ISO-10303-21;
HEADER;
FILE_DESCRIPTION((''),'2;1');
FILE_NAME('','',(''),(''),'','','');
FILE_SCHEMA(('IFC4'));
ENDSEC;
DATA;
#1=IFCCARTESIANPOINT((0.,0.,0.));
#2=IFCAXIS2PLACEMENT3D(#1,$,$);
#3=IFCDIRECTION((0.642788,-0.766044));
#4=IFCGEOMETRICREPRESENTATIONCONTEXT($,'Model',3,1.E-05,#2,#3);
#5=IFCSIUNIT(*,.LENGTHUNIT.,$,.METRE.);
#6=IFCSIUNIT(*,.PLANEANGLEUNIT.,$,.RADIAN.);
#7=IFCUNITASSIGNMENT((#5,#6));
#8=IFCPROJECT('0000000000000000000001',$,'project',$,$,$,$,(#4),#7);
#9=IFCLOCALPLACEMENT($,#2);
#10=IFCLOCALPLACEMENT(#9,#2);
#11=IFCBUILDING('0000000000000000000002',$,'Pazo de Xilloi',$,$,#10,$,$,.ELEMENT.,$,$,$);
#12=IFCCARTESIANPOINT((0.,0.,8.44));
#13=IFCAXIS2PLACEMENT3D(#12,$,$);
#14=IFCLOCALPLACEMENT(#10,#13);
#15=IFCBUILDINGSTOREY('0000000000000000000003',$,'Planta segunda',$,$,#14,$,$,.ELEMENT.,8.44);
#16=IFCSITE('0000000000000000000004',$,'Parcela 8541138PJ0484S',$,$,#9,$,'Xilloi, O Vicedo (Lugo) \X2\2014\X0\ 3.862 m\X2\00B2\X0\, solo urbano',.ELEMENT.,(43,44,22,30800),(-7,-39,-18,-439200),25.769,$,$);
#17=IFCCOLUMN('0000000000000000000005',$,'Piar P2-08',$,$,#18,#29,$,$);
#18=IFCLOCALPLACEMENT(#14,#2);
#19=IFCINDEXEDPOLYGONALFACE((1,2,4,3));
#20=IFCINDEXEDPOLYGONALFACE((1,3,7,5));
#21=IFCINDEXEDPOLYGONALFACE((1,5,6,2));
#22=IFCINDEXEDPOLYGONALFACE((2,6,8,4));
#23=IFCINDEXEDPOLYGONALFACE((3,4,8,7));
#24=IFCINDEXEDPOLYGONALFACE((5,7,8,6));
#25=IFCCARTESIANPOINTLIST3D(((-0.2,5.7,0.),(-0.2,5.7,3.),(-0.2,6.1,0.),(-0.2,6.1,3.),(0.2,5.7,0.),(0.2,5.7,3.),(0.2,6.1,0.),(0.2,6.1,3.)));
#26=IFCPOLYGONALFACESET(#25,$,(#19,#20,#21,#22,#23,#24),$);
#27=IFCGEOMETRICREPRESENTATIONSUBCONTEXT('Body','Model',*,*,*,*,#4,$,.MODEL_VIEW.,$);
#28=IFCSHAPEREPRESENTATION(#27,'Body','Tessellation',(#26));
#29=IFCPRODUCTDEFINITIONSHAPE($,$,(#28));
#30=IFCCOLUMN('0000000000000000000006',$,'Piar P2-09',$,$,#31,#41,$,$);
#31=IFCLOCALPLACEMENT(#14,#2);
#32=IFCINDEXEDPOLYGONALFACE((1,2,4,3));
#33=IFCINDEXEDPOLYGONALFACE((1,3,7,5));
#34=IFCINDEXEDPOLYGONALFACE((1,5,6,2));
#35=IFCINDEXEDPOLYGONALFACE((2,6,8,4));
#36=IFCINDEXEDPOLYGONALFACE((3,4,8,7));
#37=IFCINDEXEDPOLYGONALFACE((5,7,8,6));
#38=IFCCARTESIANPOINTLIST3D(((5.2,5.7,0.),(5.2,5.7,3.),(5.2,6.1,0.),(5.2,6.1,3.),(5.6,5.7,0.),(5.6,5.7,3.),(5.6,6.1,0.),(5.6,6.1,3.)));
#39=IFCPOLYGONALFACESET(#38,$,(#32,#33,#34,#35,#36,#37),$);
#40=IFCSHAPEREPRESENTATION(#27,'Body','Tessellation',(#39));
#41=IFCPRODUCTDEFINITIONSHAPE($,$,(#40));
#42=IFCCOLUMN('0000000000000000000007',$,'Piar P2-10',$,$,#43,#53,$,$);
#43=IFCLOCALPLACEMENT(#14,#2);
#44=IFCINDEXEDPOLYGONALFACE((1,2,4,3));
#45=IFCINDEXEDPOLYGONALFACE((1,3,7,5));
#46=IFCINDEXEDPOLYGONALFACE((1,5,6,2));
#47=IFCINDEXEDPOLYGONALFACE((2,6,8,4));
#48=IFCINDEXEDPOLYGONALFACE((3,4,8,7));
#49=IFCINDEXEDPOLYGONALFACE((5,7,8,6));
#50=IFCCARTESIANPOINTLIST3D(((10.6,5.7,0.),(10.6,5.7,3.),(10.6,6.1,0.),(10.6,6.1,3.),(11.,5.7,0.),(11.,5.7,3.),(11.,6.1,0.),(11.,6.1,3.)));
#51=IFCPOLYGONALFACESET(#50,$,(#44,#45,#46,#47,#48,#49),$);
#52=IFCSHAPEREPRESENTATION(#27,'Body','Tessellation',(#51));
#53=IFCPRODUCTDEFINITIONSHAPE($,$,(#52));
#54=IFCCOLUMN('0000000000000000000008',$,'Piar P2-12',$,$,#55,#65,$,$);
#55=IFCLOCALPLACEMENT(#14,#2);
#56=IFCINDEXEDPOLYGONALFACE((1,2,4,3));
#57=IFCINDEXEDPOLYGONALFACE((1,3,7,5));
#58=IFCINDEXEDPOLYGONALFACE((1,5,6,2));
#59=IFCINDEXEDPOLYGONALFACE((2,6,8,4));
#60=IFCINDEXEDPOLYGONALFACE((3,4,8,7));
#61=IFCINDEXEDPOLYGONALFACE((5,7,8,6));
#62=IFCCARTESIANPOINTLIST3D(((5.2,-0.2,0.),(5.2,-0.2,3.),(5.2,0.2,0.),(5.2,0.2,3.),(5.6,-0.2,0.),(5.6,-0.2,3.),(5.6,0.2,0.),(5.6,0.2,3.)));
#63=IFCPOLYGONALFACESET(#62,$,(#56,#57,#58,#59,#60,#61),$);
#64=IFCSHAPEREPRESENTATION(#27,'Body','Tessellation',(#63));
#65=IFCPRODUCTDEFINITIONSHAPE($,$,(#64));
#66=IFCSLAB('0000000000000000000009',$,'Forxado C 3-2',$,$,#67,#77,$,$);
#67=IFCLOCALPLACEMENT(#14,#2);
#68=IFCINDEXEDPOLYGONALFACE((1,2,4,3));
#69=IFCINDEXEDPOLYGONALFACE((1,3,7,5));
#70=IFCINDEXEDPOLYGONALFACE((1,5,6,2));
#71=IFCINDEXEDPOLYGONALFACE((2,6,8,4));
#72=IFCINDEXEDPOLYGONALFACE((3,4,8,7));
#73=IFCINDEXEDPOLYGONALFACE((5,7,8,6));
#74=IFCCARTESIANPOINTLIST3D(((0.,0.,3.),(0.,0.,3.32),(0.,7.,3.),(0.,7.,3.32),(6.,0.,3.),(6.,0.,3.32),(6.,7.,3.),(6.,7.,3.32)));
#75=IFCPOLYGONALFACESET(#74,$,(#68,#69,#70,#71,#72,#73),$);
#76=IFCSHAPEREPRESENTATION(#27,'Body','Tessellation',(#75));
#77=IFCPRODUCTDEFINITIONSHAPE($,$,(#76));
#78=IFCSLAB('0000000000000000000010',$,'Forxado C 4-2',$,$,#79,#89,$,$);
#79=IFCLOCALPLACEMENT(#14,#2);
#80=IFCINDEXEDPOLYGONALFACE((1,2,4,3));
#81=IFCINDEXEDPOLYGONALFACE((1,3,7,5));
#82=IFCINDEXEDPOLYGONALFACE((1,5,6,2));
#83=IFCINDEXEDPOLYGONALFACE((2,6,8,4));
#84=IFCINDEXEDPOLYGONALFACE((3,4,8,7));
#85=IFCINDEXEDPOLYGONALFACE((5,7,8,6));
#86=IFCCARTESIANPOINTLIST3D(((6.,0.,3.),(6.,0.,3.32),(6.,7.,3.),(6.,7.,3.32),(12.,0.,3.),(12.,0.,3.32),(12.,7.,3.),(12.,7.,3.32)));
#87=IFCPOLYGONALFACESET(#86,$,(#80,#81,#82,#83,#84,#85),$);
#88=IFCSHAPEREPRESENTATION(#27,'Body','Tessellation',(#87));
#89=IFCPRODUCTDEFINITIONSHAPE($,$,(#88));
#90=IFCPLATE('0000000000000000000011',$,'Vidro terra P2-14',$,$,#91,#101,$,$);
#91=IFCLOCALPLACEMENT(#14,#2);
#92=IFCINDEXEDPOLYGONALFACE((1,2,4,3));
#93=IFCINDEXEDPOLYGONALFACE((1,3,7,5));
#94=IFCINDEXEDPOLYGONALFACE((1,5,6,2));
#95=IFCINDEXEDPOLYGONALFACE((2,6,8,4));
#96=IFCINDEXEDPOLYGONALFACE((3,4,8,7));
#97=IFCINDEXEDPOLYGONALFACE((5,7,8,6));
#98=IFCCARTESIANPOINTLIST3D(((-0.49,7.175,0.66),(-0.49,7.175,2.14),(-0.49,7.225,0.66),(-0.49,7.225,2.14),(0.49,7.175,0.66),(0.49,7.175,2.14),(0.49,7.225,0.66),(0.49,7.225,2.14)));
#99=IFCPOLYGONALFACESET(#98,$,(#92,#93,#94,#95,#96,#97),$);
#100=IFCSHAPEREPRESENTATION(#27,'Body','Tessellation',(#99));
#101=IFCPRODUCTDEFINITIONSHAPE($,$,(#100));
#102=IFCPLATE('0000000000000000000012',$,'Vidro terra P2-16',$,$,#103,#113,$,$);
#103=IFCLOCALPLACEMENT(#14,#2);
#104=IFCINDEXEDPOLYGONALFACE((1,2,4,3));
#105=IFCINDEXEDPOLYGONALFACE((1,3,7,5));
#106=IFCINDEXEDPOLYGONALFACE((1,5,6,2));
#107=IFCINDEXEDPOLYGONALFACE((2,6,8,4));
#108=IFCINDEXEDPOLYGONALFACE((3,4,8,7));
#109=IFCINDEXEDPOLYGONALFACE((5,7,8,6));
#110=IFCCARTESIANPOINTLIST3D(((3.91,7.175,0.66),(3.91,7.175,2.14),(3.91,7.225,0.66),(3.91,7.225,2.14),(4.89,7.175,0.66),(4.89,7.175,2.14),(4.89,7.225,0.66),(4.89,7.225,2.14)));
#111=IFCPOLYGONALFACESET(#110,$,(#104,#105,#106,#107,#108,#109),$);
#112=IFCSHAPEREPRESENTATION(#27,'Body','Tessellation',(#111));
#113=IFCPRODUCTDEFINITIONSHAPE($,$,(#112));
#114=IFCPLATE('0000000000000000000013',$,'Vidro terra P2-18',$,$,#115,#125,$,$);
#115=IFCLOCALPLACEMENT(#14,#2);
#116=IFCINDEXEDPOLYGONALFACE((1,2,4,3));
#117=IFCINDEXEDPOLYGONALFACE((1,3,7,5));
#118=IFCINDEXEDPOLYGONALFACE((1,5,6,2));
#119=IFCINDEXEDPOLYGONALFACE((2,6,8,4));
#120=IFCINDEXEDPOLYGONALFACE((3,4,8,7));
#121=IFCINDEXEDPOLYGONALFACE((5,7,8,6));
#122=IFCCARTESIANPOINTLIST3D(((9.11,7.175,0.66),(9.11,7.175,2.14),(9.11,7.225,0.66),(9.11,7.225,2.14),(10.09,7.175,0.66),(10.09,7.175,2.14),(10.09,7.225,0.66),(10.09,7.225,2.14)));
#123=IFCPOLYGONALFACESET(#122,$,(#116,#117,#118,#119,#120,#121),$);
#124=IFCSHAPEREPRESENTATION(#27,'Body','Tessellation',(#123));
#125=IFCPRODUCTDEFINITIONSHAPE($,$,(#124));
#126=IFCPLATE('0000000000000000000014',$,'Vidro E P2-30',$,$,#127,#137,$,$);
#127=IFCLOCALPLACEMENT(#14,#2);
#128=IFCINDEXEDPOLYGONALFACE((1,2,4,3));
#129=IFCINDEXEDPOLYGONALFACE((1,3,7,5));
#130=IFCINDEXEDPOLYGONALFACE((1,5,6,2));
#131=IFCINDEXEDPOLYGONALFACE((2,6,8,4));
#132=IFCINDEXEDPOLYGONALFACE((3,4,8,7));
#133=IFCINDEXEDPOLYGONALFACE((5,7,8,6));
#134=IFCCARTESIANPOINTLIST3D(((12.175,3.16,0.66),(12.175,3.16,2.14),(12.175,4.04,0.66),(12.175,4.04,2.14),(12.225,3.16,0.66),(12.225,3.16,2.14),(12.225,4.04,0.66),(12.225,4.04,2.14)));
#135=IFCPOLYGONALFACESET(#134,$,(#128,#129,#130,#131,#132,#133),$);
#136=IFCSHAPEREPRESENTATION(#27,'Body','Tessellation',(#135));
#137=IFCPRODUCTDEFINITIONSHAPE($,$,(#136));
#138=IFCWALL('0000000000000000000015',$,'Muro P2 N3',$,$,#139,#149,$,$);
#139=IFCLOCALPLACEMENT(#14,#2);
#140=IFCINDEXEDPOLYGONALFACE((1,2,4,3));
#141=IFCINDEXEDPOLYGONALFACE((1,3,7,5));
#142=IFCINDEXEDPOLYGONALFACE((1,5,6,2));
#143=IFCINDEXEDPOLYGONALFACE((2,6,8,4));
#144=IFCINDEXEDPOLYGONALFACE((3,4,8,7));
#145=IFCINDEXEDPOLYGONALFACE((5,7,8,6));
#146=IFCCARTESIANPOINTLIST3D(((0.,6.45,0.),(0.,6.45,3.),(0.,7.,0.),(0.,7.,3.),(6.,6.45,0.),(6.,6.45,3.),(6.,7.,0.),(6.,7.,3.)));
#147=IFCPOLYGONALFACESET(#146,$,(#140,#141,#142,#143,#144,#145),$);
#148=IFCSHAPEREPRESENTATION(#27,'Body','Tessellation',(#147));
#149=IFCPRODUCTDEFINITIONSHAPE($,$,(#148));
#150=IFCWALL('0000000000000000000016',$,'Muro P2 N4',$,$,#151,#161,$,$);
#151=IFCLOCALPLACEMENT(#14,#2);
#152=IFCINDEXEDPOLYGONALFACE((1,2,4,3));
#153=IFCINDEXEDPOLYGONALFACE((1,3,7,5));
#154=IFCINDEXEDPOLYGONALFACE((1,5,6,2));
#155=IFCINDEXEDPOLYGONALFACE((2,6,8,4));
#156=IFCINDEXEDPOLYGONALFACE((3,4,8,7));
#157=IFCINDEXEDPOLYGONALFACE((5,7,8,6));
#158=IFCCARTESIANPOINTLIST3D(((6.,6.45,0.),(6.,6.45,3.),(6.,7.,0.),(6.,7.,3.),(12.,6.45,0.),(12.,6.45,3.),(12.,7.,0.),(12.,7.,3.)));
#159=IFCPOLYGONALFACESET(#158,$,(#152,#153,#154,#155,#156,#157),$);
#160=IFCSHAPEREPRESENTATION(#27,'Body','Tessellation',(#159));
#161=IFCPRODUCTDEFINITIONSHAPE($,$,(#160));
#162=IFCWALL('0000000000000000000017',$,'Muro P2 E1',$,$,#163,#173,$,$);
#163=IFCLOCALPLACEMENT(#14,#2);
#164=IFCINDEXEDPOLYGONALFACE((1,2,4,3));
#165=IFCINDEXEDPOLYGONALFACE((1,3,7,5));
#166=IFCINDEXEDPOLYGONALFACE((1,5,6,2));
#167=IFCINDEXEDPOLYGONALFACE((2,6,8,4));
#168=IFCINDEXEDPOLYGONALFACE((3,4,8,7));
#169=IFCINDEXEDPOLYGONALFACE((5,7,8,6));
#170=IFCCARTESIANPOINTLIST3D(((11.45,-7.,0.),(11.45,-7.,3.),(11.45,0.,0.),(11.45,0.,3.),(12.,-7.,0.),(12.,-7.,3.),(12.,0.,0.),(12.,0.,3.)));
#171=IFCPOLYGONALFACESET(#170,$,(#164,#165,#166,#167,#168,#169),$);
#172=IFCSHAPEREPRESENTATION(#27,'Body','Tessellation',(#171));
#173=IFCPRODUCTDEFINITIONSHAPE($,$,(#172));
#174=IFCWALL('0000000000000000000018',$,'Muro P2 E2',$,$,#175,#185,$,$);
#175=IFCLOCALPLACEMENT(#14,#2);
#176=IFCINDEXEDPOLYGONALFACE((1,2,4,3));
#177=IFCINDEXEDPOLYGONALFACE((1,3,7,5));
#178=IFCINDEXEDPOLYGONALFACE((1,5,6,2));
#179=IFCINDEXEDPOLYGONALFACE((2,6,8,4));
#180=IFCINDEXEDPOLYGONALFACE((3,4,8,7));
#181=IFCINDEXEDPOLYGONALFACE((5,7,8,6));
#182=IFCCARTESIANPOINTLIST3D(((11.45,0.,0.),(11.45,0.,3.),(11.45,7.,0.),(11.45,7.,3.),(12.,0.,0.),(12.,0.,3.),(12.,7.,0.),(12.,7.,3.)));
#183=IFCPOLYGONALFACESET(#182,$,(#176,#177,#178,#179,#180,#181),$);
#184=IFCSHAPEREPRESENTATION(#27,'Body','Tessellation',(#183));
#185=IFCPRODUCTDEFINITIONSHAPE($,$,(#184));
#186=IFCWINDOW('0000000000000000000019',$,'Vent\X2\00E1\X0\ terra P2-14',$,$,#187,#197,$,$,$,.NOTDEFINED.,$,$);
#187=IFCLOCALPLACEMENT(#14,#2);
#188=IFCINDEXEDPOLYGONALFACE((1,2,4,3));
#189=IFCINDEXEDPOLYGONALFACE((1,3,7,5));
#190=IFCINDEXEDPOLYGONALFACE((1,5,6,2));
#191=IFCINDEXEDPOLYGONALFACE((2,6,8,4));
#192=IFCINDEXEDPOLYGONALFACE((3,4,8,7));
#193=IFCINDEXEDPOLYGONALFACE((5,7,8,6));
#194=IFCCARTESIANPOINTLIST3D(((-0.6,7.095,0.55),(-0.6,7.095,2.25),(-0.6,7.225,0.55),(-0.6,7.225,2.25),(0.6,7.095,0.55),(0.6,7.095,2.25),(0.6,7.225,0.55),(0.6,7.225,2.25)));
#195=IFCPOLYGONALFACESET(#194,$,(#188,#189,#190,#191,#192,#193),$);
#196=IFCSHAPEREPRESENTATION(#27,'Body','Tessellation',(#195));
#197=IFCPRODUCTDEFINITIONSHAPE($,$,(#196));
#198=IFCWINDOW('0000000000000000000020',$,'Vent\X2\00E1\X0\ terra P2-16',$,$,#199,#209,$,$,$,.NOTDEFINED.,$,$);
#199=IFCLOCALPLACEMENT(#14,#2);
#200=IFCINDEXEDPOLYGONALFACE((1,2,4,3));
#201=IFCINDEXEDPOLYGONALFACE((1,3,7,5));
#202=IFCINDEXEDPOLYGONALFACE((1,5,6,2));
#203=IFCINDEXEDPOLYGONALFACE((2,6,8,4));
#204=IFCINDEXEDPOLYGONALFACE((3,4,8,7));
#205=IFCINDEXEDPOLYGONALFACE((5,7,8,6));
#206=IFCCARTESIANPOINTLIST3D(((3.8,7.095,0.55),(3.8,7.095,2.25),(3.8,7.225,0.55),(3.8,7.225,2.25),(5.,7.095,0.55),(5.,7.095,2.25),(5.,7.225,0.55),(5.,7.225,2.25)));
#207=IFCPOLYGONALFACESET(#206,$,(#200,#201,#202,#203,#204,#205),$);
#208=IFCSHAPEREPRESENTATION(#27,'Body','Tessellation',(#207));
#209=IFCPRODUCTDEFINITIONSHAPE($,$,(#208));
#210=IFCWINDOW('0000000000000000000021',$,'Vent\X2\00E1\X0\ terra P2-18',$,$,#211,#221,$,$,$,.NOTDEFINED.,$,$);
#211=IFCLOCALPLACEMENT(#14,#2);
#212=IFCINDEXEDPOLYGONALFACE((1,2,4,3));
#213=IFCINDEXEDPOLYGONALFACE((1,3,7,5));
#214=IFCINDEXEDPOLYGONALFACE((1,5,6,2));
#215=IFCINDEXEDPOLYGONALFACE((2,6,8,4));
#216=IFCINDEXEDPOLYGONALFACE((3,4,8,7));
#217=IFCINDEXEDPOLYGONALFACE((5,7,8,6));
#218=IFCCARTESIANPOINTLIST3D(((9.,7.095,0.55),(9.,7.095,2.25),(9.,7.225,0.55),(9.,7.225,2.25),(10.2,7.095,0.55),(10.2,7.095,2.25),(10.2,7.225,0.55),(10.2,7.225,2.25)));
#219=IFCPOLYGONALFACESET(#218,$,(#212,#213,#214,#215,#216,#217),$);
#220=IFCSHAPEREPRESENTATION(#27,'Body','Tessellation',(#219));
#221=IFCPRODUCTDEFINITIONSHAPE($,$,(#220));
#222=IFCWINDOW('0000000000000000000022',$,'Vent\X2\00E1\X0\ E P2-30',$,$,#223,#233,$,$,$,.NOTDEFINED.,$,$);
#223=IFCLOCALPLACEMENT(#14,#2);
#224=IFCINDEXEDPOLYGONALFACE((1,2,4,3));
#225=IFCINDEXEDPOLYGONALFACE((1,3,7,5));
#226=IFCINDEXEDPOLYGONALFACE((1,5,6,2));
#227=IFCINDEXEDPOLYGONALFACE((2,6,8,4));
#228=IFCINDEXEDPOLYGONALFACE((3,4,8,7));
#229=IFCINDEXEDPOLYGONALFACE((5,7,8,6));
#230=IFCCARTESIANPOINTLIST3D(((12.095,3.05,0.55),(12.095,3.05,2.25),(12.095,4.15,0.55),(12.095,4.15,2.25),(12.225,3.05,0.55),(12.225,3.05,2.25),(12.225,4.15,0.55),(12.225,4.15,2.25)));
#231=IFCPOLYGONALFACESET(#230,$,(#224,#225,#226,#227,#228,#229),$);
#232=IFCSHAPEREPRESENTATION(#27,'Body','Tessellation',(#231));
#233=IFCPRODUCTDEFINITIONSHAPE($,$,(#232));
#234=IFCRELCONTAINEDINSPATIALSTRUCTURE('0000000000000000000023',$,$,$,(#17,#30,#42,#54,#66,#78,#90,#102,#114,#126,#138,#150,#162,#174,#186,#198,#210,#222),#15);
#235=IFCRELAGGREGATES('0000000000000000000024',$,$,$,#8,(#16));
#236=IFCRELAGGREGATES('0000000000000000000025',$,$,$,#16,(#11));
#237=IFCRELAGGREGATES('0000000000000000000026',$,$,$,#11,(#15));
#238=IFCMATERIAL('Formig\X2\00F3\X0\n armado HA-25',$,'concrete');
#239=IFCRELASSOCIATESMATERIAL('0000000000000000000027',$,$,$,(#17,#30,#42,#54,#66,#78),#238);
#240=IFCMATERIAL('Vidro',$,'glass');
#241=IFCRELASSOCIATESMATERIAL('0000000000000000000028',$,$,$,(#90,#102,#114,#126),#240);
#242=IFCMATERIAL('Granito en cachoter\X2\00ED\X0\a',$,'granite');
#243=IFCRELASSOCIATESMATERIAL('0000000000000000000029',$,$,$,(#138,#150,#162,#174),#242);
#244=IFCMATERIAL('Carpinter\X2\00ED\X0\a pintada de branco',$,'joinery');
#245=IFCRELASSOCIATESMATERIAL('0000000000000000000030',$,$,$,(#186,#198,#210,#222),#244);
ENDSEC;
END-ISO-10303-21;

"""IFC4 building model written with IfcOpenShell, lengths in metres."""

from ifc_helpers import new_model, si_unit, direction, frame, origin, origin_2d, place, context, subcontext, project, spatial, rectangle, extrude, material, element, save


model = new_model("IFC4")

# Units and contexts
model_context = context("Model", 3, precision=1e-05, world=origin(), true_north=direction((0.642788, -0.766044)))
body_context = subcontext(model_context, "Body", "Model", "MODEL_VIEW")
ifc_project = project(units=[si_unit("LENGTHUNIT", "METRE"), si_unit("PLANEANGLEUNIT", "RADIAN")], contexts=[model_context])

# Site, building, storey
site_placement = place(None, origin())
site = spatial("IfcSite", under=ifc_project, at=site_placement, Name="Parcela 8541138PJ0484S", LongName="Xilloi, O Vicedo (Lugo) — 3.862 m², solo urbano", CompositionType="ELEMENT", RefLatitude=(43, 44, 22, 30800), RefLongitude=(-7, -39, -18, -439200), RefElevation=25.769)
building_placement = place(site_placement, origin())
building = spatial("IfcBuilding", under=site, at=building_placement, Name="Pazo de Xilloi", CompositionType="ELEMENT")
storey_placement = place(building_placement, frame((0.0, 0.0, 8.44)))
storey = spatial("IfcBuildingStorey", under=building, at=storey_placement, Name="Planta segunda", CompositionType="ELEMENT", Elevation=8.44)

# Columns
ifc_material_1 = material(Name="Formigón armado HA-25", Category="concrete")
for number, where, name in (
    (1, (0.0, 5.9, 1.5), "Piar P2-08"),
    (2, (5.4, 5.9, 1.5), "Piar P2-09"),
    (3, (10.8, 5.9, 1.5), "Piar P2-10"),
    (4, (5.4, 0.0, 1.5), "Piar P2-12"),
):
    element("IfcColumn", number, at=place(storey_placement, frame(where)), inside=storey, material=ifc_material_1, Name=name, context=body_context, shape_type="SweptSolid", body=[
        extrude(rectangle(XDim=0.4, YDim=0.4, at=origin_2d()), frame((0.0, 0.0, -1.5)), (0.0, 0.0, 1.0), 3.0),
    ])

# Slabs
for number, where, name in (
    (5, (3.0, 3.5, 3.16), "Forxado C 3-2"),
    (6, (9.0, 3.5, 3.16), "Forxado C 4-2"),
):
    element("IfcSlab", number, at=place(storey_placement, frame(where)), inside=storey, material=ifc_material_1, Name=name, context=body_context, shape_type="SweptSolid", body=[
        extrude(rectangle(XDim=6.0, YDim=7.0, at=origin_2d()), frame((0.0, 0.0, -0.16)), (0.0, 0.0, 1.0), 0.32),
    ])

# Plates
ifc_material_2 = material(Name="Vidro", Category="glass")
for number, where, name in (
    (7, (0.0, 7.2, 1.4), "Vidro terra P2-14"),
    (8, (4.4, 7.2, 1.4), "Vidro terra P2-16"),
    (9, (9.6, 7.2, 1.4), "Vidro terra P2-18"),
):
    element("IfcPlate", number, at=place(storey_placement, frame(where)), inside=storey, material=ifc_material_2, Name=name, context=body_context, shape_type="SweptSolid", body=[
        extrude(rectangle(XDim=0.98, YDim=0.05, at=origin_2d()), frame((0.0, 0.0, -0.74)), (0.0, 0.0, 1.0), 1.48),
    ])
plate_placement = place(storey_placement, frame((12.2, 3.6, 1.4)))
element("IfcPlate", 10, at=plate_placement, inside=storey, material=ifc_material_2, Name="Vidro E P2-30", context=body_context, shape_type="SweptSolid", body=[
    extrude(rectangle(XDim=0.05, YDim=0.88, at=origin_2d()), frame((0.0, 0.0, -0.74)), (0.0, 0.0, 1.0), 1.48),
])

# Walls
ifc_material_3 = material(Name="Granito en cachotería", Category="granite")
for number, where, name in (
    (11, (3.0, 6.725, 1.5), "Muro P2 N3"),
    (12, (9.0, 6.725, 1.5), "Muro P2 N4"),
):
    element("IfcWall", number, at=place(storey_placement, frame(where)), inside=storey, material=ifc_material_3, Name=name, context=body_context, shape_type="SweptSolid", body=[
        extrude(rectangle(XDim=6.0, YDim=0.55, at=origin_2d()), frame((0.0, 0.0, -1.5)), (0.0, 0.0, 1.0), 3.0),
    ])
for number, where, name in (
    (13, (11.725, -3.5, 1.5), "Muro P2 E1"),
    (14, (11.725, 3.5, 1.5), "Muro P2 E2"),
):
    element("IfcWall", number, at=place(storey_placement, frame(where)), inside=storey, material=ifc_material_3, Name=name, context=body_context, shape_type="SweptSolid", body=[
        extrude(rectangle(XDim=0.55, YDim=7.0, at=origin_2d()), frame((0.0, 0.0, -1.5)), (0.0, 0.0, 1.0), 3.0),
    ])

# Windows
ifc_material_4 = material(Name="Carpintería pintada de branco", Category="joinery")
for number, where, name in (
    (15, (0.0, 7.16, 1.4), "Ventá terra P2-14"),
    (16, (4.4, 7.16, 1.4), "Ventá terra P2-16"),
    (17, (9.6, 7.16, 1.4), "Ventá terra P2-18"),
):
    element("IfcWindow", number, at=place(storey_placement, frame(where)), inside=storey, material=ifc_material_4, Name=name, PredefinedType="NOTDEFINED", context=body_context, shape_type="SweptSolid", body=[
        extrude(rectangle(XDim=1.2, YDim=0.13, at=origin_2d()), frame((0.0, 0.0, -0.85)), (0.0, 0.0, 1.0), 1.7),
    ])
window_placement = place(storey_placement, frame((12.16, 3.6, 1.4)))
element("IfcWindow", 18, at=window_placement, inside=storey, material=ifc_material_4, Name="Ventá E P2-30", PredefinedType="NOTDEFINED", context=body_context, shape_type="SweptSolid", body=[
    extrude(rectangle(XDim=0.13, YDim=1.1, at=origin_2d()), frame((0.0, 0.0, -0.85)), (0.0, 0.0, 1.0), 1.7),
])

save(model, "model.ifc")
